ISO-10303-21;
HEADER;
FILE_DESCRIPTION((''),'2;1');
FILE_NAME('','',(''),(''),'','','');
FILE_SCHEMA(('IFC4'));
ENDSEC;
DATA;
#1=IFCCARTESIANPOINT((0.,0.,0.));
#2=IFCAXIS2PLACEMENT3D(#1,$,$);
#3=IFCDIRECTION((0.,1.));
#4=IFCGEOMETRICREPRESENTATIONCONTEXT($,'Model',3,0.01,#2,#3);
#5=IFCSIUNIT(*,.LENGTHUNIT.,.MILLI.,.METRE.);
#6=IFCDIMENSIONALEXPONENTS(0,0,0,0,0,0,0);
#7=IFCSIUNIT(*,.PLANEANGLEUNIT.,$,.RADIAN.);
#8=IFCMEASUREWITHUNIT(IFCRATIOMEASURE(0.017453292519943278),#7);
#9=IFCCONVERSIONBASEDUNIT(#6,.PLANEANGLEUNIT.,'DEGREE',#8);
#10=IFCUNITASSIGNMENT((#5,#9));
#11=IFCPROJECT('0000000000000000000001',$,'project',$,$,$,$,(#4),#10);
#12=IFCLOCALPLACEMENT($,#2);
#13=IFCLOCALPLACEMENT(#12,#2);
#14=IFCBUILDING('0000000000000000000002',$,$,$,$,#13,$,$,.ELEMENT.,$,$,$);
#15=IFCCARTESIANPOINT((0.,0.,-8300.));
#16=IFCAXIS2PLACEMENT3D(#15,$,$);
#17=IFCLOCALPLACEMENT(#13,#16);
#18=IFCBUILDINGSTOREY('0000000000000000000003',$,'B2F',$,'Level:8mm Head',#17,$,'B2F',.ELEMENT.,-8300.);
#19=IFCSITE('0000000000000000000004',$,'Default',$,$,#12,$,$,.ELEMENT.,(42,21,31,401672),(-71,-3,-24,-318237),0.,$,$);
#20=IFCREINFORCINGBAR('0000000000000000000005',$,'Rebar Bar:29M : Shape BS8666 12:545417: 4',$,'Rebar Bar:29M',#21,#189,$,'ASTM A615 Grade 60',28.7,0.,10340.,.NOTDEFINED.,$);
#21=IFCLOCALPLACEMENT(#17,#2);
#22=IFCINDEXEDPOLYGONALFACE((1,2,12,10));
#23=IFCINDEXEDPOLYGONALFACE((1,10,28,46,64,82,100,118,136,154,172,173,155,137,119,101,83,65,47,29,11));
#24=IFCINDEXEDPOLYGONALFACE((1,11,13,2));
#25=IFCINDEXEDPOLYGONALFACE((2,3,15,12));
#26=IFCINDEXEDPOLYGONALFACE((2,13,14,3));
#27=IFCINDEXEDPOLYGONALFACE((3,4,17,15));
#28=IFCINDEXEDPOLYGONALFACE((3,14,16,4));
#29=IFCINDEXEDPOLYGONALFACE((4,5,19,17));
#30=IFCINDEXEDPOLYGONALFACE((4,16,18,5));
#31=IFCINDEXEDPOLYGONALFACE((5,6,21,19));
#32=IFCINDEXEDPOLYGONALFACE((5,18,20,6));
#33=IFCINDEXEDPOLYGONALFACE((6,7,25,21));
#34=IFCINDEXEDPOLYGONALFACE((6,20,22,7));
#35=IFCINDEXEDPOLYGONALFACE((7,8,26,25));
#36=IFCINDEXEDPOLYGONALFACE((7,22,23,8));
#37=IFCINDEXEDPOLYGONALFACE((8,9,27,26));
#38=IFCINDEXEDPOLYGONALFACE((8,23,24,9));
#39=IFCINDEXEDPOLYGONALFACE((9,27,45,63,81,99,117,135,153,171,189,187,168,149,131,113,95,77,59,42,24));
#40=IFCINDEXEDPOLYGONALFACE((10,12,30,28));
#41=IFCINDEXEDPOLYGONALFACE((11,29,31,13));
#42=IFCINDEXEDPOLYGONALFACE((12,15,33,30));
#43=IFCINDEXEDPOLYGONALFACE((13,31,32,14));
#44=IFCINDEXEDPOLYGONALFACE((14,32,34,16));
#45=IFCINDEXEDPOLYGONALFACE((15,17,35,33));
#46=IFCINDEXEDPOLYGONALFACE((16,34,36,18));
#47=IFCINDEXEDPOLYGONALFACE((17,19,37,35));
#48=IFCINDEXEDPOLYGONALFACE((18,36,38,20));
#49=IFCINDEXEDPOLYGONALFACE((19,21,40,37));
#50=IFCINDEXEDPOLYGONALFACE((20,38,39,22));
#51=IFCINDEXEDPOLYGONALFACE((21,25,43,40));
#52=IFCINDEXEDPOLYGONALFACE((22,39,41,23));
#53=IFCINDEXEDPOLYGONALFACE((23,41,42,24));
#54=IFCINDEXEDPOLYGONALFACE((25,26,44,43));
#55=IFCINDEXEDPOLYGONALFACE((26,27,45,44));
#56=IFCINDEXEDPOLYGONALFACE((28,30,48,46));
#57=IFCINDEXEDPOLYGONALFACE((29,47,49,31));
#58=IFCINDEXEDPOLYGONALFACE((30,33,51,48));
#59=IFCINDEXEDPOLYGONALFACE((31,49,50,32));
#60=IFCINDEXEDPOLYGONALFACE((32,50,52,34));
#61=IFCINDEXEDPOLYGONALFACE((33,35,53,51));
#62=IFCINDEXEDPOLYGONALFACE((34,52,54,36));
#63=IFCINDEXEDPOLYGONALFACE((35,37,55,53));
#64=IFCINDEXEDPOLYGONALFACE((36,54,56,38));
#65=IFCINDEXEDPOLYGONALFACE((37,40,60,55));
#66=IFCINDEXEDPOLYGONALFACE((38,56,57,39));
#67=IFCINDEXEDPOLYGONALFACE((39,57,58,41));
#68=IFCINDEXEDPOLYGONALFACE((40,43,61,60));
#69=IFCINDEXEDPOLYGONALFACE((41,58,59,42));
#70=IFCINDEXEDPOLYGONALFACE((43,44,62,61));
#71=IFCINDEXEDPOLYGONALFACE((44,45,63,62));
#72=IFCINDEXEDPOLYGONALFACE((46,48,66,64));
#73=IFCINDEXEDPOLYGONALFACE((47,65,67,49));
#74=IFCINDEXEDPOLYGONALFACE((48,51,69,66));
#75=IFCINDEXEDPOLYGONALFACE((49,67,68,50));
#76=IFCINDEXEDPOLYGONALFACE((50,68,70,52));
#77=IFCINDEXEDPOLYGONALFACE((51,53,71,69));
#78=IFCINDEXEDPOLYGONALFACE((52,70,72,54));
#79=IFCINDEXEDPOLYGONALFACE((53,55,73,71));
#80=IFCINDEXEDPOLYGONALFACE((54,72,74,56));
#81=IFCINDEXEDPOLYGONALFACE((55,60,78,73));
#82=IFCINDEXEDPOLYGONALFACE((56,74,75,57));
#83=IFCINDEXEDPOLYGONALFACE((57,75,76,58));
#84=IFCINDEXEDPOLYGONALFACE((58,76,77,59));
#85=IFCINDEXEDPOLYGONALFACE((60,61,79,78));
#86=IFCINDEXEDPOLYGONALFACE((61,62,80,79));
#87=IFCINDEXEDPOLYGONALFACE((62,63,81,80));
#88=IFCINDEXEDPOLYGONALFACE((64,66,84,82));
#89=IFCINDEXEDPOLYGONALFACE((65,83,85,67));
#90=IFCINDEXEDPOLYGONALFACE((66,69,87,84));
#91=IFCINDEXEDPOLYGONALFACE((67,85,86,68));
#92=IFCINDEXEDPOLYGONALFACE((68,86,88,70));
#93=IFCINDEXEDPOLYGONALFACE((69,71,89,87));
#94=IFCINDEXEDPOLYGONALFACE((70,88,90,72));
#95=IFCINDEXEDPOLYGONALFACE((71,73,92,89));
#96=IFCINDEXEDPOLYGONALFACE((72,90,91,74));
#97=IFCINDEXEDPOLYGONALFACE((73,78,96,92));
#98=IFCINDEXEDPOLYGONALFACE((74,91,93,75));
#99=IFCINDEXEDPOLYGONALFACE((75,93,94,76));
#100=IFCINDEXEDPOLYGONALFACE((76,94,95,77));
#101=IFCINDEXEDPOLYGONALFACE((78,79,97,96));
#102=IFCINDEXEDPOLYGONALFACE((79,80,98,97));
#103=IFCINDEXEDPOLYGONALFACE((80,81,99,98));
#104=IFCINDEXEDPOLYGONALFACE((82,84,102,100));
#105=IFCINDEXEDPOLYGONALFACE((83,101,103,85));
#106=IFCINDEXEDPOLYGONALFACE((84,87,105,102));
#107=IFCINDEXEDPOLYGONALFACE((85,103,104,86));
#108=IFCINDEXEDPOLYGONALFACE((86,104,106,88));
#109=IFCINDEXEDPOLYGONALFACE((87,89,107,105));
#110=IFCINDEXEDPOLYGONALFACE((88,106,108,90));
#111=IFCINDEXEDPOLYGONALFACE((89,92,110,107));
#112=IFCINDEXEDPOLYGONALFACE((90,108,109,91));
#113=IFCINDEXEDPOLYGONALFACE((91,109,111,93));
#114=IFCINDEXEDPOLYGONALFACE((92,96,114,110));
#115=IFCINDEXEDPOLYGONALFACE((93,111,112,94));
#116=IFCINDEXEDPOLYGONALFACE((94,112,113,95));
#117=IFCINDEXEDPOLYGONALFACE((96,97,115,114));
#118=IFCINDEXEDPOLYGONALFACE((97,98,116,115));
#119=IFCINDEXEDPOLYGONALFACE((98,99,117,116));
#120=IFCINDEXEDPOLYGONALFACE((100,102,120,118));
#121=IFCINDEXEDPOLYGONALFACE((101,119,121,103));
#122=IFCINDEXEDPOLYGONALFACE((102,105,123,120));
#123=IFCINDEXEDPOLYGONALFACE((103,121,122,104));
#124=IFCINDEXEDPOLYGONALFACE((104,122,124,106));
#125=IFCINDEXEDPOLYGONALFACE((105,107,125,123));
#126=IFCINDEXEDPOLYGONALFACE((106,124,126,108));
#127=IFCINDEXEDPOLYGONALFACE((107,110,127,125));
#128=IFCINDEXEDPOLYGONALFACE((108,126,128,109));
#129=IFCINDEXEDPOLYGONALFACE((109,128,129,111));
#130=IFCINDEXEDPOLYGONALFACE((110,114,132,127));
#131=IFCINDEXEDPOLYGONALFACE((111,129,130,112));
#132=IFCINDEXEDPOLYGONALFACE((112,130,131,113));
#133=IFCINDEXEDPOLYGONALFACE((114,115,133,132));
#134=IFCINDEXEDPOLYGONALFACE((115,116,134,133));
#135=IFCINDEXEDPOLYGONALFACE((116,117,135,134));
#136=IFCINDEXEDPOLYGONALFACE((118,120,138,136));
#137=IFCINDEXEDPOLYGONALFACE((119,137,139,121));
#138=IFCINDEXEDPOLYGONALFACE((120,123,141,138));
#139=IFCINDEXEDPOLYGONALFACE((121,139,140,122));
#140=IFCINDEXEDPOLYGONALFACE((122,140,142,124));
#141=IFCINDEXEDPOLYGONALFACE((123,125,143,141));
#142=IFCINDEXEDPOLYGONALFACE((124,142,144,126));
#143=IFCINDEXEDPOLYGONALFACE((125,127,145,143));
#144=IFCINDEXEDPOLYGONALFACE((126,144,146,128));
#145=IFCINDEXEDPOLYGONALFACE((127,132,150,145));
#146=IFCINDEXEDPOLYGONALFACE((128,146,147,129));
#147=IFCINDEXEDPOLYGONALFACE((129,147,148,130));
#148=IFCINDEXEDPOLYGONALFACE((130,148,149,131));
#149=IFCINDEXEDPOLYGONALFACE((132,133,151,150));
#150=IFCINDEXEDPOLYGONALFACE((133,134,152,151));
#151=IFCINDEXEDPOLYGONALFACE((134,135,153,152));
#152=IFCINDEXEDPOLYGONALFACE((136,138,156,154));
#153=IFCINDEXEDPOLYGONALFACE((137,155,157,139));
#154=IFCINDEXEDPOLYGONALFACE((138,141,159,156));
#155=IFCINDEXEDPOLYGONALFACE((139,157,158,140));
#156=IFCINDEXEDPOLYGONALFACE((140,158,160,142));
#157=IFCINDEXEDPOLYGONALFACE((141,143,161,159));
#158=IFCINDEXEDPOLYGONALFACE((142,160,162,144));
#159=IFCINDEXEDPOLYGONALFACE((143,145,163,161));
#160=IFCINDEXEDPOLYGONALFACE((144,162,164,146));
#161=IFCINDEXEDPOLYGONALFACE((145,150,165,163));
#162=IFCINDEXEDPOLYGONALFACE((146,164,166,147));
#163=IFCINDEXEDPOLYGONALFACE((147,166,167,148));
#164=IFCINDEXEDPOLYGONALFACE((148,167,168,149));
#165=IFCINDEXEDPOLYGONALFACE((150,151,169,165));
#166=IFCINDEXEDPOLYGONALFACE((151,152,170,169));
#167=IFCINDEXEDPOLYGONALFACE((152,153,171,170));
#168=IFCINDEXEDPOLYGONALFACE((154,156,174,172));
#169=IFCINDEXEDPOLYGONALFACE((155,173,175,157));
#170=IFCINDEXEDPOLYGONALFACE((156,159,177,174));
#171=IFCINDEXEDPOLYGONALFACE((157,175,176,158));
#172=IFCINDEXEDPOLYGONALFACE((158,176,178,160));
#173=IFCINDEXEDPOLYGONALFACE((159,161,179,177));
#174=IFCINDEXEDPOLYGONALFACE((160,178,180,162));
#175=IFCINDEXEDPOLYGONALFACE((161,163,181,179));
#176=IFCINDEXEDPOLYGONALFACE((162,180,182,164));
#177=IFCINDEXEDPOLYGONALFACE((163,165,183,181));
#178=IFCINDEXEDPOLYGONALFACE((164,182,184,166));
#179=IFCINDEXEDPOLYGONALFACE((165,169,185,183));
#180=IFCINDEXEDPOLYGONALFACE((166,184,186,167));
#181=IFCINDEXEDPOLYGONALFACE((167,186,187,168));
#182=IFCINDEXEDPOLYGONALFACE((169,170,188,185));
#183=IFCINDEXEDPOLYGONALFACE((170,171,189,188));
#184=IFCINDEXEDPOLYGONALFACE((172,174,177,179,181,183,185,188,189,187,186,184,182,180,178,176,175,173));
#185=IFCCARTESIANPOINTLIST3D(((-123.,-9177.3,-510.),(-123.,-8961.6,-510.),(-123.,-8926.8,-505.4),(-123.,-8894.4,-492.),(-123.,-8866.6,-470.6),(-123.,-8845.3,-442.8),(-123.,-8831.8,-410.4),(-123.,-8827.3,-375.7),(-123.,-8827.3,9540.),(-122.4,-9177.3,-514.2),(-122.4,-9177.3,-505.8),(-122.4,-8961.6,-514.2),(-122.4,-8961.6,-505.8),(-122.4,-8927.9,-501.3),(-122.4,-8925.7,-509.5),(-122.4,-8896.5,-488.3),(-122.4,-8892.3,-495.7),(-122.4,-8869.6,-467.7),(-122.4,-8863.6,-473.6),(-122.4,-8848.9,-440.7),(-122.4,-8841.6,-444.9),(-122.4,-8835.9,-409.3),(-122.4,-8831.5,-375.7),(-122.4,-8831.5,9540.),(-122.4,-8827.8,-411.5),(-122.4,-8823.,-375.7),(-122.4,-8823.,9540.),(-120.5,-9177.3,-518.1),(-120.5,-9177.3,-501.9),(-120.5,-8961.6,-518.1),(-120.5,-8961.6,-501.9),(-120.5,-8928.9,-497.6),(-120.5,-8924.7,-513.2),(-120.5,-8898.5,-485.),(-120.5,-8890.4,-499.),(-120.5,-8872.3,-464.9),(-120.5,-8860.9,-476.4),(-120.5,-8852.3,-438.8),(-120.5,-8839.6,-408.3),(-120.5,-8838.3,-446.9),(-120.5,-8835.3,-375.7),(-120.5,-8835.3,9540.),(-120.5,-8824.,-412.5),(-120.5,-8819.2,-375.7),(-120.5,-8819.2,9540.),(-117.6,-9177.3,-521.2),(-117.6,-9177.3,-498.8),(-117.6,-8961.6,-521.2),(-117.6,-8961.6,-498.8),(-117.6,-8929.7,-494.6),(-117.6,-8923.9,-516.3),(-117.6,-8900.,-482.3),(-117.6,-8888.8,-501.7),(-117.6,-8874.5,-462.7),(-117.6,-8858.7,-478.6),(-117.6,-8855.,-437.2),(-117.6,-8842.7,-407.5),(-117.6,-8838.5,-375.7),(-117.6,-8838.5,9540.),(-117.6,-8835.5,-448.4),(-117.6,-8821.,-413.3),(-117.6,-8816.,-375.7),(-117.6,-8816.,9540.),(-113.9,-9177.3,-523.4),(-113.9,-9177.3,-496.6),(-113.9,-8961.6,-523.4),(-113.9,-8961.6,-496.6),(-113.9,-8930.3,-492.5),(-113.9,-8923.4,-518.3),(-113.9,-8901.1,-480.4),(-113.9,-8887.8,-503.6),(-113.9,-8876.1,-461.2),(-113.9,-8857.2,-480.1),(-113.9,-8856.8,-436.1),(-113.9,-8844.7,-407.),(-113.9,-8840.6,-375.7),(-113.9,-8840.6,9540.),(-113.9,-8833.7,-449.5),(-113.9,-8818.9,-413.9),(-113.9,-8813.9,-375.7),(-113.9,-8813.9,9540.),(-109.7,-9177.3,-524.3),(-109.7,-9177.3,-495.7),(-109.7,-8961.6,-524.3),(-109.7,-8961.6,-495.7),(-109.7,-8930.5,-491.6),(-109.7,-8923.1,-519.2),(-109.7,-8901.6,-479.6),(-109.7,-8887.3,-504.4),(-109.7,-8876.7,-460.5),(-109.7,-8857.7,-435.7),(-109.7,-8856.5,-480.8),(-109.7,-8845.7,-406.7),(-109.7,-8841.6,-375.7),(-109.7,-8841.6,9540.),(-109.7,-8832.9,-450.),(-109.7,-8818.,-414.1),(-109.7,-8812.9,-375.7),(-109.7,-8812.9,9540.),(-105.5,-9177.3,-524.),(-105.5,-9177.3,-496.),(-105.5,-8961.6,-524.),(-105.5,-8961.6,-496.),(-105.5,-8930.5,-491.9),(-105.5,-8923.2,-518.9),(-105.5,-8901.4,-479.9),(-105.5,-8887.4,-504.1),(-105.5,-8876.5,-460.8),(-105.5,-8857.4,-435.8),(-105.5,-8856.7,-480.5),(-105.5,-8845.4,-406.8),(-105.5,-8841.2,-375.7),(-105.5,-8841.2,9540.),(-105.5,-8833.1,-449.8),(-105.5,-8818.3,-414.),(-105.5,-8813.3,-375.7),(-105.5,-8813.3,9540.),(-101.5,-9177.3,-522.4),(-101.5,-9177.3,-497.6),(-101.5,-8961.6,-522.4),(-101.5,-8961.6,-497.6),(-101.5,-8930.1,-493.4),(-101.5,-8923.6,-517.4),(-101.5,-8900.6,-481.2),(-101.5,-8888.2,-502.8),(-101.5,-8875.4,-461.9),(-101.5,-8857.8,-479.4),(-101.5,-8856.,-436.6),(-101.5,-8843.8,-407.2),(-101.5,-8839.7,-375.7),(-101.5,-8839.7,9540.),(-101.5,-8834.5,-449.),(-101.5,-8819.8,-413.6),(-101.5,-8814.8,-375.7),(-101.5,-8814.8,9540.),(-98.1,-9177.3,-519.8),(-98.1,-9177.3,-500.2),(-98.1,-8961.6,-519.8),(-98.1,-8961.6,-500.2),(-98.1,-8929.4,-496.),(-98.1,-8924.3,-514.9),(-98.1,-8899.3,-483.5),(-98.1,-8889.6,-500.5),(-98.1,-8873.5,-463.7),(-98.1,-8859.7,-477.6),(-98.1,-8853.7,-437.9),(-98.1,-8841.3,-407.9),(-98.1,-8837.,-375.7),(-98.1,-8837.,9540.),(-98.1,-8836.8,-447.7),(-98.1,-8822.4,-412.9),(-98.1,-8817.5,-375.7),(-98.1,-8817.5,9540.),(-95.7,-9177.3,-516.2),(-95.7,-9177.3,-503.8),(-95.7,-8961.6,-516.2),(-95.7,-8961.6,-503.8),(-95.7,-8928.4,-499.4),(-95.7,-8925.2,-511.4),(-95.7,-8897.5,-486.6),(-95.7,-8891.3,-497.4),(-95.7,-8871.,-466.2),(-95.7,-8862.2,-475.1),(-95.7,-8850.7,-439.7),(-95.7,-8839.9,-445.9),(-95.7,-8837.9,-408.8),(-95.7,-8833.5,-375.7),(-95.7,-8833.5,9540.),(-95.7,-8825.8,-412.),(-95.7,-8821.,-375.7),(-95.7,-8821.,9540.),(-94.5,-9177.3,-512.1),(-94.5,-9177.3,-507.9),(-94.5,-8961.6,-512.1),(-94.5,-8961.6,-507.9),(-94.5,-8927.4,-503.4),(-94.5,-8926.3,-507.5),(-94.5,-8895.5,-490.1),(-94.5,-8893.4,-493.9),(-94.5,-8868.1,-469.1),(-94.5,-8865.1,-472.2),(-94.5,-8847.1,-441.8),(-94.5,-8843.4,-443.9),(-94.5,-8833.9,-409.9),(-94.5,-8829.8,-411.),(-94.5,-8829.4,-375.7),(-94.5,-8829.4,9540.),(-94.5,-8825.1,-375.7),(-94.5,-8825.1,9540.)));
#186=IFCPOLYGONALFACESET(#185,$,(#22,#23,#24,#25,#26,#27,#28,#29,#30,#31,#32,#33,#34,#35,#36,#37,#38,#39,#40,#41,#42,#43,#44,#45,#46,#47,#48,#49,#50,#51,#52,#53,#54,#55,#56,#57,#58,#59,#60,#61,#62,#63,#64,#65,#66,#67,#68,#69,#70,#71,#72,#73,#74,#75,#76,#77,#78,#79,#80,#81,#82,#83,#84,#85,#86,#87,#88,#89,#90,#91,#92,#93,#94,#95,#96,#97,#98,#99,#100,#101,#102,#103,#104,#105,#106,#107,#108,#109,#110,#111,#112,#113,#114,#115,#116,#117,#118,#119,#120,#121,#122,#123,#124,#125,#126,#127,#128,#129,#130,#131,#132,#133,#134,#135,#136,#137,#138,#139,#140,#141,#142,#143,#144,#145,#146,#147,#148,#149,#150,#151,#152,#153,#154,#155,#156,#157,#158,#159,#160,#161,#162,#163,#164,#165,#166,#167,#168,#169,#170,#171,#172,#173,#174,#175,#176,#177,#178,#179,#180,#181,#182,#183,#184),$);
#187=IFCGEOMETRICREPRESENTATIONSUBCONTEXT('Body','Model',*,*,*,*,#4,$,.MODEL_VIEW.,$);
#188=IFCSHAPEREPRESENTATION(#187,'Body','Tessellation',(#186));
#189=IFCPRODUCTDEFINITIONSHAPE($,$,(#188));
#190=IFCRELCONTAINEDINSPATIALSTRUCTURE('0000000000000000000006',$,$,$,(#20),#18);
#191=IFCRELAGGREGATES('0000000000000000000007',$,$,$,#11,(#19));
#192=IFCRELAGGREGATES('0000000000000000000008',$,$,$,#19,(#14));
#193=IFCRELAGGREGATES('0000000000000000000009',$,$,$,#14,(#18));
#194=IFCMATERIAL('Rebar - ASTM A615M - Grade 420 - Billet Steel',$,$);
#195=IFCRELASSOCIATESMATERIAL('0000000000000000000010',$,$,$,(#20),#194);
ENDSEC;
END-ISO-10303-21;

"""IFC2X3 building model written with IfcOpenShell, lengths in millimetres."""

from ifc_helpers import new_model, entity, si_unit, converted_unit, direction, frame, origin, place, context, subcontext, project, spatial, material, element, save


model = new_model("IFC2X3")

# Units and contexts
model_context = context("Model", 3, precision=0.01, world=origin(), true_north=direction((0.0, 1.0)))
body_context = subcontext(model_context, "Body", "Model", "MODEL_VIEW")
ifc_project = project(units=[si_unit("LENGTHUNIT", "METRE", prefix="MILLI"), converted_unit("PLANEANGLEUNIT", "DEGREE", entity("IfcRatioMeasure", 0.017453292519943278), si_unit("PLANEANGLEUNIT", "RADIAN"), dimensions=[0, 0, 0, 0, 0, 0, 0])], contexts=[model_context])

# Site, building, storey
site_placement = place(None, origin())
site = spatial("IfcSite", under=ifc_project, at=site_placement, Name="Default", CompositionType="ELEMENT", RefLatitude=(42, 21, 31, 401672), RefLongitude=(-71, -3, -24, -318237), RefElevation=0.0)
building_placement = place(site_placement, origin())
building = spatial("IfcBuilding", under=site, at=building_placement, CompositionType="ELEMENT")
storey_placement = place(building_placement, frame((0.0, 0.0, -8300.0)))
storey = spatial("IfcBuildingStorey", under=building, at=storey_placement, Name="B2F", ObjectType="Level:8mm Head", LongName="B2F", CompositionType="ELEMENT", Elevation=-8300.0)

# Reinforcing bar
ifc_material_1 = material(Name="Rebar - ASTM A615M - Grade 420 - Billet Steel")
reinforcing_bar_1_placement = place(storey_placement, origin())
element("IfcReinforcingBar", 1, at=reinforcing_bar_1_placement, inside=storey, material=ifc_material_1, Name="Rebar Bar:29M : Shape BS8666 12:545417: 4", SteelGrade="ASTM A615 Grade 60", ObjectType="Rebar Bar:29M", BarLength=10340.0, BarRole="NOTDEFINED", CrossSectionArea=0.0, NominalDiameter=28.7, context=body_context, shape_type="AdvancedSweptSolid", body=[
    entity("IfcSweptDiskSolid", entity("IfcCompositeCurve", [entity("IfcCompositeCurveSegment", "CONTINUOUS", True, entity("IfcPolyline", [entity("IfcCartesianPoint", [-108.6, -8827.3, 9540.0]), entity("IfcCartesianPoint", [-108.6, -8827.3, -375.7])])), entity("IfcCompositeCurveSegment", "CONTINUOUS", True, entity("IfcTrimmedCurve", entity("IfcCircle", entity("IfcAxis2Placement3D", entity("IfcCartesianPoint", [-108.6, -8961.6, -375.7]), entity("IfcDirection", [-1.0, 0.0, 0.0]), entity("IfcDirection", [0.0, 0.0, -1.0])), 134.3), [entity("IfcParameterValue", 270.0)], [entity("IfcParameterValue", 360.0)], True, "PARAMETER")), entity("IfcCompositeCurveSegment", "CONTINUOUS", True, entity("IfcPolyline", [entity("IfcCartesianPoint", [-108.6, -8961.6, -510.0]), entity("IfcCartesianPoint", [-108.6, -9177.3, -510.0])]))], False), 14.3, None, 0.0, 92.0),
])

save(model, "model.ifc")
